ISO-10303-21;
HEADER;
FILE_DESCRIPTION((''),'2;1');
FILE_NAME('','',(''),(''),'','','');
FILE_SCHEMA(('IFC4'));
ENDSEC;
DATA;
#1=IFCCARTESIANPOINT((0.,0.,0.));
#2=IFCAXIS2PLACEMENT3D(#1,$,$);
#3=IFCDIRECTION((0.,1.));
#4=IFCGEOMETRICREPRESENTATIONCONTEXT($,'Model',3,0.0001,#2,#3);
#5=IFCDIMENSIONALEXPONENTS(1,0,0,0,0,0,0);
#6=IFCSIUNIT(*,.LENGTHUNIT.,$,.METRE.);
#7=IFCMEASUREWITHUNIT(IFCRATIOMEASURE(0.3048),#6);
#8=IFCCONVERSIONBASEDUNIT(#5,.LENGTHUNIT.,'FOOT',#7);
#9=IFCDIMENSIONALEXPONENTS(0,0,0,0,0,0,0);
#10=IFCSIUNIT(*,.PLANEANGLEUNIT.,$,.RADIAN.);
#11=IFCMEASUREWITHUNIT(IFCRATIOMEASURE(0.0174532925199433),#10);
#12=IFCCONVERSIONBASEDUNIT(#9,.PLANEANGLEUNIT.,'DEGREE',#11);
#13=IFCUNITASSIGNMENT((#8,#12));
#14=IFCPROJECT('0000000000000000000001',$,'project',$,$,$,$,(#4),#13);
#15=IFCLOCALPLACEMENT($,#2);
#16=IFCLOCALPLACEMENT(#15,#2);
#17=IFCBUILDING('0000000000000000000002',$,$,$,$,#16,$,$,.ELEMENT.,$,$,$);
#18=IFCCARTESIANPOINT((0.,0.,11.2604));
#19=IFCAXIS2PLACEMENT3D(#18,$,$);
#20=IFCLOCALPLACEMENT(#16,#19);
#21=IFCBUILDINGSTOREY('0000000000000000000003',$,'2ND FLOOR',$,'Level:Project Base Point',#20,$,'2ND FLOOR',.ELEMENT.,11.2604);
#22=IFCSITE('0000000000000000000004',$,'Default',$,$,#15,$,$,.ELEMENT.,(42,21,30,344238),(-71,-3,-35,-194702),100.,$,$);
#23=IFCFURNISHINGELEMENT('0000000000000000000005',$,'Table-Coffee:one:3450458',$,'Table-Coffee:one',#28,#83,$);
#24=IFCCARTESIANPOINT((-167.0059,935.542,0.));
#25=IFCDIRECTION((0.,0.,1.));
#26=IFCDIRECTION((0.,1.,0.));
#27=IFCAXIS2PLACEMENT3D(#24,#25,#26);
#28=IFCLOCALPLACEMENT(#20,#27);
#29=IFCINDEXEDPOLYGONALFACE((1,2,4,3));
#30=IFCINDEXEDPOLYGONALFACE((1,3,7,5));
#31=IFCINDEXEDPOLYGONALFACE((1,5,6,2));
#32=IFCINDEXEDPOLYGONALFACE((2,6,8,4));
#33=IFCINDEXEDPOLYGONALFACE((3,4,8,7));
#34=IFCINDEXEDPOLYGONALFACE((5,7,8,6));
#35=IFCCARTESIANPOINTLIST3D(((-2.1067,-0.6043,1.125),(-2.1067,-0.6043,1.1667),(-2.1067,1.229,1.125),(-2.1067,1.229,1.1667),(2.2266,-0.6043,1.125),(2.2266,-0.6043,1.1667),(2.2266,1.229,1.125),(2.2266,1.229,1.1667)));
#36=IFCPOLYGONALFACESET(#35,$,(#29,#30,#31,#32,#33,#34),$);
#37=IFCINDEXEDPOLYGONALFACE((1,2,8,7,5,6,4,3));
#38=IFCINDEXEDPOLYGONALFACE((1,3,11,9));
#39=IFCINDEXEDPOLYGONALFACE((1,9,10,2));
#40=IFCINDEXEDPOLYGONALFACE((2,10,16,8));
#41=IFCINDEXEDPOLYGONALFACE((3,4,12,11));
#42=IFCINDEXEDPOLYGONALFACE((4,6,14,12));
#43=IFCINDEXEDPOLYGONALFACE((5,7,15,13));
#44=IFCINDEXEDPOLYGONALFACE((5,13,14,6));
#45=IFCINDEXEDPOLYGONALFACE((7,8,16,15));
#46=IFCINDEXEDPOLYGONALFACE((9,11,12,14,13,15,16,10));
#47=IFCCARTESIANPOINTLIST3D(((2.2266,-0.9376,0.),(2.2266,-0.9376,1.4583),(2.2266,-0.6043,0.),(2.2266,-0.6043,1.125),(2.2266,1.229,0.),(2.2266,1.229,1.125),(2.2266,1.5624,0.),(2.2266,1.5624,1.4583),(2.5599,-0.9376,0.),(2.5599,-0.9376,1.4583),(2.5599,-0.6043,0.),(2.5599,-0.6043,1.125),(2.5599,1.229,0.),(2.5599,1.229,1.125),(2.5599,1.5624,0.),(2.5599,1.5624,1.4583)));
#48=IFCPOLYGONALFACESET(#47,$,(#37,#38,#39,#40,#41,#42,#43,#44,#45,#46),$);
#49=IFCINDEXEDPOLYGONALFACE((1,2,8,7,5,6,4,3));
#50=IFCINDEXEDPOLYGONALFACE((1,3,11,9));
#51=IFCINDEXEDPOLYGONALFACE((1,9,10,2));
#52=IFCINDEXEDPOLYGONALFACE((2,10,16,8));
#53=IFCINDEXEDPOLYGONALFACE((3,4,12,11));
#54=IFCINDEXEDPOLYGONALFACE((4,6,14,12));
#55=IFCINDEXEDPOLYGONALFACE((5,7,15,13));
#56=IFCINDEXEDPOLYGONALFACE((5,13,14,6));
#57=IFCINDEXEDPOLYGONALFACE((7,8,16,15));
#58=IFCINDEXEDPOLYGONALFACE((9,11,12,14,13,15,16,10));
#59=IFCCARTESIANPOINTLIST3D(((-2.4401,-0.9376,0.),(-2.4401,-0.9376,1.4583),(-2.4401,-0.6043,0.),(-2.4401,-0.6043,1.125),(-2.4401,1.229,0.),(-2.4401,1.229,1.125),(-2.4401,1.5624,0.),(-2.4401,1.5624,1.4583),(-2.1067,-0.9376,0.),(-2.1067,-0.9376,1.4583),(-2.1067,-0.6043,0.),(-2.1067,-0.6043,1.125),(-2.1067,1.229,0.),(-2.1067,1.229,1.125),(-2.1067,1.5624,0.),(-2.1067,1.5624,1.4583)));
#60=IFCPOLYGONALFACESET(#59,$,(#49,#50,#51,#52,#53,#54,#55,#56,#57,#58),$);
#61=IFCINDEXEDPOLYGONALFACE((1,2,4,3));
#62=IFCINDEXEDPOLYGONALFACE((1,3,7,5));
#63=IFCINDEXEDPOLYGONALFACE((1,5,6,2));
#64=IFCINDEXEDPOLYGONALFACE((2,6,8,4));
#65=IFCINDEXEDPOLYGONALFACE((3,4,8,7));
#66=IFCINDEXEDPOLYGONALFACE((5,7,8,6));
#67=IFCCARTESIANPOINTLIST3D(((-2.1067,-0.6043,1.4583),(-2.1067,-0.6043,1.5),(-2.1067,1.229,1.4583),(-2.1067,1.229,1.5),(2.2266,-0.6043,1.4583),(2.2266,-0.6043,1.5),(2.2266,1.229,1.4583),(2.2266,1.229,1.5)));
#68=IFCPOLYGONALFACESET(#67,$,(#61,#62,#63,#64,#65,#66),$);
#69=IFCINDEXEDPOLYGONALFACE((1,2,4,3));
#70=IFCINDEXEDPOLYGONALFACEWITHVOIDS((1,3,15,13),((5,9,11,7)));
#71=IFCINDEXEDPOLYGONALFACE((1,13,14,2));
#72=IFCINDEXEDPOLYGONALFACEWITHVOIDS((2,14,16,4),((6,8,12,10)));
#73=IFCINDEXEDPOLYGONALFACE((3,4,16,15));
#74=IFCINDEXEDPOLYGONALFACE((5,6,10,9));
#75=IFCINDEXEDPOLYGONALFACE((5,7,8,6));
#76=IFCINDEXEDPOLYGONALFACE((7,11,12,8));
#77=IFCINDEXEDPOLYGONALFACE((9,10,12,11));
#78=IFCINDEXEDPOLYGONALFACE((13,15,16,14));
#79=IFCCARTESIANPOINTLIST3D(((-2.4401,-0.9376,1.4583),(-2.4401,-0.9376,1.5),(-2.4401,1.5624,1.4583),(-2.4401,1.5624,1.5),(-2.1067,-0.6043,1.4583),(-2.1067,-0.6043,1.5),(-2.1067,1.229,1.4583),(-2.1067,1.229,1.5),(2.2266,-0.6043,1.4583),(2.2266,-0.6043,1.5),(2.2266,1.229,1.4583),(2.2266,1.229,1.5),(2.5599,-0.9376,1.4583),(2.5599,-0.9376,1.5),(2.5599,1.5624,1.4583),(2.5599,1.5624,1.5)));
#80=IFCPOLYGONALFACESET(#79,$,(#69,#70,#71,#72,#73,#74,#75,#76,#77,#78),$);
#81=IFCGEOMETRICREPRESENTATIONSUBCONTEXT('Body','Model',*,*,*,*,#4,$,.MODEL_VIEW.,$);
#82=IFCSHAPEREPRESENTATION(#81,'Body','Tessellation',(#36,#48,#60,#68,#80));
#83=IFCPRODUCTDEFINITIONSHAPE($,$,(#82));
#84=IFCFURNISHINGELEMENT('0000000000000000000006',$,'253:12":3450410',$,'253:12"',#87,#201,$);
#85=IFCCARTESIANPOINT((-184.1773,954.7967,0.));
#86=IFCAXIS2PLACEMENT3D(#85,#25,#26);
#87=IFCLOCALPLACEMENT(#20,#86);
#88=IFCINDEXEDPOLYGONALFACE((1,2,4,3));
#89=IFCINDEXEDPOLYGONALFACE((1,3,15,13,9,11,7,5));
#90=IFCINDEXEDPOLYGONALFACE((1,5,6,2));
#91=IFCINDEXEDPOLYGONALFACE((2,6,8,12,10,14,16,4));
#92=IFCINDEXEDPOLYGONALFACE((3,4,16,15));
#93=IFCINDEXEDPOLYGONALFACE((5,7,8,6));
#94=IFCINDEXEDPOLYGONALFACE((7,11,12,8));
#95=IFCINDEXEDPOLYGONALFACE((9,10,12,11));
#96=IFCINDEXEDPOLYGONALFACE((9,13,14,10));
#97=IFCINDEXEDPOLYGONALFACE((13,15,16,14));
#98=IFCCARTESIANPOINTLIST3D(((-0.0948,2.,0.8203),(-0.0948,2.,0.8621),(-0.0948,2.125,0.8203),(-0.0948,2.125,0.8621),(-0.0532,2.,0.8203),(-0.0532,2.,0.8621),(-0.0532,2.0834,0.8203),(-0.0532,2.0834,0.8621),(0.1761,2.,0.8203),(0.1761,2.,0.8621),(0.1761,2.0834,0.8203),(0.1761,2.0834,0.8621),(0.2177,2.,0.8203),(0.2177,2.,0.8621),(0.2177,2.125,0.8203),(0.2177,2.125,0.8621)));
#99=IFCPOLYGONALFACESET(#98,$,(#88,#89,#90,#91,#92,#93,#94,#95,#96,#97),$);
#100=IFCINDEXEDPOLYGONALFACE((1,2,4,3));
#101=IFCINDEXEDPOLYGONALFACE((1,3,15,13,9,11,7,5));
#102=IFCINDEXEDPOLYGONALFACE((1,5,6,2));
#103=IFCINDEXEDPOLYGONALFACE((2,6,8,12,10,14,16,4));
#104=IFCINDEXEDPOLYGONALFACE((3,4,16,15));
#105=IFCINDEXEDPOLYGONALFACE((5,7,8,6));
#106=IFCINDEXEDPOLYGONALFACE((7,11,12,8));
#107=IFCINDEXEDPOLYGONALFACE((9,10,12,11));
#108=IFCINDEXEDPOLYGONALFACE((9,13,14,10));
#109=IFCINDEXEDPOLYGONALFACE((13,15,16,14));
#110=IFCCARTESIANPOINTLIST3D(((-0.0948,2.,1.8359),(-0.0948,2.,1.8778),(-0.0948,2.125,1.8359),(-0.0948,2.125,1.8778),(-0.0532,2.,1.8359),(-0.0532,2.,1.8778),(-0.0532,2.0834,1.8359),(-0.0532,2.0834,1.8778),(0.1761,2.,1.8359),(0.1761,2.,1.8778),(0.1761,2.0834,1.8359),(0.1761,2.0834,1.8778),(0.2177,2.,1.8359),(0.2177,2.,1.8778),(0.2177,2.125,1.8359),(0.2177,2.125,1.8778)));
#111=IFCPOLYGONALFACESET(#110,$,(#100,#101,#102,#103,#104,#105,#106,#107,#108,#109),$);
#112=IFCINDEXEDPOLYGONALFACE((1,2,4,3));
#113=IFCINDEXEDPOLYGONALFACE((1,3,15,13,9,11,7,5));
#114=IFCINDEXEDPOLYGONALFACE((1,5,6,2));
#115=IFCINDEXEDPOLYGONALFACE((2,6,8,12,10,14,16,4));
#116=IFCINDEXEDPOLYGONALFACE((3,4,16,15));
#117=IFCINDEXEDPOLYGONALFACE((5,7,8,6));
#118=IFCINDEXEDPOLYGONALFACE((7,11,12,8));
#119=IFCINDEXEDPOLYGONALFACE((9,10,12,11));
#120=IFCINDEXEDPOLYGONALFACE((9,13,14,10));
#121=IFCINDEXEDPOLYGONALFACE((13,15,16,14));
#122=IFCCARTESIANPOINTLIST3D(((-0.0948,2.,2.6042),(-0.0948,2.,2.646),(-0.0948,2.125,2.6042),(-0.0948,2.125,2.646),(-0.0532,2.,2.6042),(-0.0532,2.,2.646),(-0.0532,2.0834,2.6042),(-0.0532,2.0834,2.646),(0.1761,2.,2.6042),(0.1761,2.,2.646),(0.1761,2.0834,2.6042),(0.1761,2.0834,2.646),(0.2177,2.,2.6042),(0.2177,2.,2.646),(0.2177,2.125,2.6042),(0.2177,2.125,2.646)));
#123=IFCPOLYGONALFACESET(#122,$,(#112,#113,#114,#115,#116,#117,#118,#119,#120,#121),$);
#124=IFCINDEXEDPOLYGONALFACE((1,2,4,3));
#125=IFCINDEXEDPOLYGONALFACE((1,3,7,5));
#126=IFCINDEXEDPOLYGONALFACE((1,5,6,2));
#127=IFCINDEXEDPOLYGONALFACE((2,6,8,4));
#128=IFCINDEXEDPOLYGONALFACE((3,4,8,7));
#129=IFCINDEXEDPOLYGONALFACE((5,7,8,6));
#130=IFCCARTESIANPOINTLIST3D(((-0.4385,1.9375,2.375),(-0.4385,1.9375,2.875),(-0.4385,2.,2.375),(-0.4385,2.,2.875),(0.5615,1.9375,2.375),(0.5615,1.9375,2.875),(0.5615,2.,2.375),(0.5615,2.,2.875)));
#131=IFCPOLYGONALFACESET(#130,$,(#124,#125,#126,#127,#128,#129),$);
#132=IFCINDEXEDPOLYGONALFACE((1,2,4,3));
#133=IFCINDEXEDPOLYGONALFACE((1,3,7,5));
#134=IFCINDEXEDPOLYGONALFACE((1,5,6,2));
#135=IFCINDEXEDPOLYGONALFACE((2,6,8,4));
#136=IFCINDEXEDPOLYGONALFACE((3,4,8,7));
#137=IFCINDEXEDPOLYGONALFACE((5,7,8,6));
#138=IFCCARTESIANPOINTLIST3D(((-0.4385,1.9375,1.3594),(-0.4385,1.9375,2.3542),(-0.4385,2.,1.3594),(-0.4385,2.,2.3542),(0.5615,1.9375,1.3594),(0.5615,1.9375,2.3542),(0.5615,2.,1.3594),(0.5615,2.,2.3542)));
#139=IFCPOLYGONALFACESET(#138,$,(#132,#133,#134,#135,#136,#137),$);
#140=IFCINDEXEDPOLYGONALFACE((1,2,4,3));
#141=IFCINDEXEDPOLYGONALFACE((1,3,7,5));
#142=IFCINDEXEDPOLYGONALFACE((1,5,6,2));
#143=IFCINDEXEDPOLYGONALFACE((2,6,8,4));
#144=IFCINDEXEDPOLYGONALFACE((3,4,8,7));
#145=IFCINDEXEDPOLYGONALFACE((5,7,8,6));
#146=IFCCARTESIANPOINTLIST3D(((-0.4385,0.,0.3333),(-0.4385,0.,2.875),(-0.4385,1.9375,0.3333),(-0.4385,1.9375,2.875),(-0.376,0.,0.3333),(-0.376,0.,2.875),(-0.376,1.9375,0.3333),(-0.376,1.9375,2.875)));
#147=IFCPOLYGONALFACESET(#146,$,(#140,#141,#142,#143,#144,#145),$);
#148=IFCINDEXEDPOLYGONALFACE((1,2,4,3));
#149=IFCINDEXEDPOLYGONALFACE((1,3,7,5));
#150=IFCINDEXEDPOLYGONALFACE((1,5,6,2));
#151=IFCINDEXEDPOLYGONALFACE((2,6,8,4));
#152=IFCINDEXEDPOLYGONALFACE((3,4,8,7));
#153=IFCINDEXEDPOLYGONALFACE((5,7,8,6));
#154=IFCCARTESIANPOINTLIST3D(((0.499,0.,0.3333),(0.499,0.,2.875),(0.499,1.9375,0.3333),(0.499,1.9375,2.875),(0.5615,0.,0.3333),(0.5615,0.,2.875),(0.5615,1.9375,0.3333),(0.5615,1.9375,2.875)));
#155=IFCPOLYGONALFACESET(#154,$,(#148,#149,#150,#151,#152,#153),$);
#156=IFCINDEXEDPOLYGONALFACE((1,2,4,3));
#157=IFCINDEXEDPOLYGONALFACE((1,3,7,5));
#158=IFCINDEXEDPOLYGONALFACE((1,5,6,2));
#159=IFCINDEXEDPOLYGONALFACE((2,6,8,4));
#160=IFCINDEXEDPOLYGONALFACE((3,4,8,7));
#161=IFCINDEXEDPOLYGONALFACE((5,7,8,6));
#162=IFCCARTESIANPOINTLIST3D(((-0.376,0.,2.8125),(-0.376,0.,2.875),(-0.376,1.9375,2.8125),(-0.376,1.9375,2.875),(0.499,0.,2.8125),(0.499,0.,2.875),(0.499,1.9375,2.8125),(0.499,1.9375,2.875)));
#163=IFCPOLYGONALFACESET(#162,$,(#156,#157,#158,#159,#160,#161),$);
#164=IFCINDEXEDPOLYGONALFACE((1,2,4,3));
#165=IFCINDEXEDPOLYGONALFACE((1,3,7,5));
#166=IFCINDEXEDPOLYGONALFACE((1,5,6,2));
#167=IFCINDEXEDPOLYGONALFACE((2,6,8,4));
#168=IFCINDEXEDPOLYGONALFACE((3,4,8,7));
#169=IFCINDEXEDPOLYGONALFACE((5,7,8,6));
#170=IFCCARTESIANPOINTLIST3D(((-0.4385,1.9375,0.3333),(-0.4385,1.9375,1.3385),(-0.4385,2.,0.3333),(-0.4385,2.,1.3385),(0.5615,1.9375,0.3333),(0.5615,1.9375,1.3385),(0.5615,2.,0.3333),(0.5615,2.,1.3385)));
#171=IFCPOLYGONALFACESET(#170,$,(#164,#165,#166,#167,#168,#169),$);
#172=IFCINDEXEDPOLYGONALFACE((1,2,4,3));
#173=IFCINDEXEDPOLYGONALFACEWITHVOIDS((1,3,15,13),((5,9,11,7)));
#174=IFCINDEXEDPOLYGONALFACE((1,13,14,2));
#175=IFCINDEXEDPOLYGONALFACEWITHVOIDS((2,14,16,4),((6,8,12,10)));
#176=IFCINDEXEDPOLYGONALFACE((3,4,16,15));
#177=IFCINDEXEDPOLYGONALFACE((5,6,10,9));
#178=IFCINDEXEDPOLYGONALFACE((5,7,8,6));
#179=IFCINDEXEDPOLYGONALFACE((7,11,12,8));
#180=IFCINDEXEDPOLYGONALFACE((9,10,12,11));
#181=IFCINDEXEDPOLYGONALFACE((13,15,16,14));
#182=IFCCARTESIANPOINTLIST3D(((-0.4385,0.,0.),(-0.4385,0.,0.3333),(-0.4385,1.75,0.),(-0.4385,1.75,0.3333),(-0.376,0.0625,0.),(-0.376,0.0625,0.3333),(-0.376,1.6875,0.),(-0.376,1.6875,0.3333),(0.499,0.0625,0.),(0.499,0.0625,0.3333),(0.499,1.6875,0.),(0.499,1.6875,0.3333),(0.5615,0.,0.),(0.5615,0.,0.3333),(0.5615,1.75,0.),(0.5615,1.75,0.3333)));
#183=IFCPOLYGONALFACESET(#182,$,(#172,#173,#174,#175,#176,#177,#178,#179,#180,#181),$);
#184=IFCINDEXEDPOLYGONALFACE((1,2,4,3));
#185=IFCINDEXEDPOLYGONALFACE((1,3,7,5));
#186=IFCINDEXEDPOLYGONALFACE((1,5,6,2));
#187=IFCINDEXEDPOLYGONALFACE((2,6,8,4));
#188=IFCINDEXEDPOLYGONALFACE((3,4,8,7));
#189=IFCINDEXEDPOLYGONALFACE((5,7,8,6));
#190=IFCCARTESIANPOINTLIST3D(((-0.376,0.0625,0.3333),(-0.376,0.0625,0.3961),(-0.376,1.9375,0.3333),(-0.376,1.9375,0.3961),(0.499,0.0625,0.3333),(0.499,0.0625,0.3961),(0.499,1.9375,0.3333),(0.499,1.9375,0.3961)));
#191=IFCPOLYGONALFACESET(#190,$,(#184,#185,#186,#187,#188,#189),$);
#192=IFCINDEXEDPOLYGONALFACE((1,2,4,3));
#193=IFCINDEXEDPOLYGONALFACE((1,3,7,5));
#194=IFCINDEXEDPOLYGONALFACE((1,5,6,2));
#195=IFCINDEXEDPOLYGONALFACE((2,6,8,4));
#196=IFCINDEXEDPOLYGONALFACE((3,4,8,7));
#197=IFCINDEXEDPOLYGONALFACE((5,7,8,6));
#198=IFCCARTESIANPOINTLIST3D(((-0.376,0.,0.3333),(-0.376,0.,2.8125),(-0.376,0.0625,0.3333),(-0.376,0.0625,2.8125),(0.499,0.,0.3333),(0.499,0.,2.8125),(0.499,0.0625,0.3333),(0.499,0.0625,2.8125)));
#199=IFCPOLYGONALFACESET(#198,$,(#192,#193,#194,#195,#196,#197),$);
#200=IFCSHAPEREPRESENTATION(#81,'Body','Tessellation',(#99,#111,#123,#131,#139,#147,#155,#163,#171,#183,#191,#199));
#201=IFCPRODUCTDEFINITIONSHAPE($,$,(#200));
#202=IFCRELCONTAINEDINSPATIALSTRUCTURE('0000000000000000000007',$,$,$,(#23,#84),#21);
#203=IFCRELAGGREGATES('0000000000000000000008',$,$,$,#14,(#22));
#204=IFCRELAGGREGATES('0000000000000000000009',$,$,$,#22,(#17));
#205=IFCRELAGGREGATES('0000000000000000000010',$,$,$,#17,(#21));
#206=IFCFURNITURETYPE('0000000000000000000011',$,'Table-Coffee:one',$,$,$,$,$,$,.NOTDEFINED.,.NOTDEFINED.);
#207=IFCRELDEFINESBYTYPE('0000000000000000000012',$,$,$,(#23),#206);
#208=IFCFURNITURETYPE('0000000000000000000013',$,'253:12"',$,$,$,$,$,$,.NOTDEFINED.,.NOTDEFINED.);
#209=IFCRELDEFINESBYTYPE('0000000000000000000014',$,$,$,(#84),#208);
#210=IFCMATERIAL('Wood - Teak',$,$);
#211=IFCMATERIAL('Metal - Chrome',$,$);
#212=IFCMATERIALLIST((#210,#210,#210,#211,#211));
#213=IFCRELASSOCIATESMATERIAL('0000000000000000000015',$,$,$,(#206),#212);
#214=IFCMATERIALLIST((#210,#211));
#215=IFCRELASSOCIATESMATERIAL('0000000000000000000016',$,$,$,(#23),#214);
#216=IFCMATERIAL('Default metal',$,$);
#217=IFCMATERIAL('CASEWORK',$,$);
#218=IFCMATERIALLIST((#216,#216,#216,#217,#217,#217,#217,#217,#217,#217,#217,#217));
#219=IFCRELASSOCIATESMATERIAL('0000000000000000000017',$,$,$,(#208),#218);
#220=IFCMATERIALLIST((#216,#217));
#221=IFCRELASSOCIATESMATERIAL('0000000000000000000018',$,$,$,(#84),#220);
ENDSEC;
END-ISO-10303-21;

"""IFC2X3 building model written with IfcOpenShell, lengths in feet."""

from ifc_helpers import new_model, entity, si_unit, converted_unit, direction, frame, frame_2d, origin, origin_2d_with_axis, place, context, subcontext, project, spatial, polyline, rectangle, outline, extrude, source, transform, mapped, material, material_list, type_object, type_shapes, element, save


model = new_model("IFC2X3")

# Units and contexts
model_context = context("Model", 3, precision=0.0001, world=origin(), true_north=direction((0.0, 1.0)))
body_context = subcontext(model_context, "Body", "Model", "MODEL_VIEW")
ifc_project = project(units=[converted_unit("LENGTHUNIT", "FOOT", entity("IfcRatioMeasure", 0.3048), si_unit("LENGTHUNIT", "METRE"), dimensions=[1, 0, 0, 0, 0, 0, 0]), converted_unit("PLANEANGLEUNIT", "DEGREE", entity("IfcRatioMeasure", 0.0174532925199433), si_unit("PLANEANGLEUNIT", "RADIAN"), dimensions=[0, 0, 0, 0, 0, 0, 0])], contexts=[model_context])

# Site, building, storey
site_placement = place(None, origin())
site = spatial("IfcSite", under=ifc_project, at=site_placement, Name="Default", CompositionType="ELEMENT", RefLatitude=(42, 21, 30, 344238), RefLongitude=(-71, -3, -35, -194702), RefElevation=100.0)
building_placement = place(site_placement, origin())
building = spatial("IfcBuilding", under=site, at=building_placement, CompositionType="ELEMENT")
storey_placement = place(building_placement, frame((0.0, 0.0, 11.2604)))
storey = spatial("IfcBuildingStorey", under=building, at=storey_placement, Name="2ND FLOOR", ObjectType="Level:Project Base Point", LongName="2ND FLOOR", CompositionType="ELEMENT", Elevation=11.2604)

# Furnishing elements
ifc_material_1 = material(Name="Wood - Teak")
ifc_material_2 = material(Name="Metal - Chrome")
ifc_material_list_1 = material_list([ifc_material_1, ifc_material_2])
ifc_material_list_2 = material_list([ifc_material_1, ifc_material_1, ifc_material_1, ifc_material_2, ifc_material_2])
furniture_type_1 = type_object("IfcFurnitureType", Name="Table-Coffee:one", material=ifc_material_list_2)
shared_shape_1 = source(origin(), body_context, "Body", "SweptSolid", [
    extrude(rectangle(XDim=4.3333, YDim=1.8333, at=origin_2d_with_axis()), frame((0.0599, 0.3124, 1.125), z_axis=(0.0, 0.0, 1.0), x_axis=(-1.0, 0.0, 0.0)), (0.0, 0.0, 1.0), 0.0417),
    extrude(outline(polyline([(-0.6458, -1.25), (0.8125, -1.25), (0.8125, 1.25), (-0.6458, 1.25), (-0.6458, 0.9167), (0.4792, 0.9167), (0.4792, -0.9167), (-0.6458, -0.9167), (-0.6458, -1.25)])), frame((2.2266, 0.3124, 0.6458), z_axis=(1.0, 0.0, 0.0), x_axis=(0.0, 0.0, 1.0)), (0.0, 0.0, 1.0), 0.3333),
    extrude(outline(polyline([(-1.25, -0.8125), (1.25, -0.8125), (1.25, 0.6458), (0.9167, 0.6458), (0.9167, -0.4792), (-0.9167, -0.4792), (-0.9167, 0.6458), (-1.25, 0.6458), (-1.25, -0.8125)])), frame((-2.4401, 0.3124, 0.6458), z_axis=(1.0, 0.0, 0.0), x_axis=(0.0, -1.0, 0.0)), (0.0, 0.0, 1.0), 0.3333),
    extrude(rectangle(XDim=4.3333, YDim=1.8333, at=origin_2d_with_axis()), frame((0.0599, 0.3124, 1.4583), z_axis=(0.0, 0.0, 1.0), x_axis=(-1.0, 0.0, 0.0)), (0.0, 0.0, 1.0), 0.0417),
    extrude(outline(polyline([(-2.5, -1.25), (2.5, -1.25), (2.5, 1.25), (-2.5, 1.25), (-2.5, -1.25)]), holes=[polyline([(-2.1667, -0.9167), (-2.1667, 0.9167), (2.1667, 0.9167), (2.1667, -0.9167), (-2.1667, -0.9167)])]), frame((0.0599, 0.3124, 1.4583), z_axis=(0.0, 0.0, 1.0), x_axis=(-1.0, 0.0, 0.0)), (0.0, 0.0, 1.0), 0.0417),
])
type_shapes(furniture_type_1, [shared_shape_1])
furnishing_1_placement = place(storey_placement, frame((-167.0059, 935.542, 0.0), z_axis=(0.0, 0.0, 1.0), x_axis=(0.0, 1.0, 0.0)))
element("IfcFurnishingElement", 1, at=furnishing_1_placement, inside=storey, type_object=furniture_type_1, material=ifc_material_list_1, Name="Table-Coffee:one:3450458", ObjectType="Table-Coffee:one", context=body_context, shape_type="MappedRepresentation", body=[
    mapped(shared_shape_1, transform((0.0, 0.0, 0.0), scale=1.0)),
])
ifc_material_3 = material(Name="Default metal")
ifc_material_4 = material(Name="CASEWORK")
ifc_material_list_3 = material_list([ifc_material_3, ifc_material_4])
ifc_material_list_4 = material_list([ifc_material_3, ifc_material_3, ifc_material_3, ifc_material_4, ifc_material_4, ifc_material_4, ifc_material_4, ifc_material_4, ifc_material_4, ifc_material_4, ifc_material_4, ifc_material_4])
furniture_type_2 = type_object("IfcFurnitureType", Name="253:12\"", material=ifc_material_list_4)
shared_shape_2 = source(origin(), body_context, "Body", "SweptSolid", [
    extrude(outline(polyline([(-0.1562, -0.0521), (-0.1146, -0.0521), (-0.1146, 0.0313), (0.1146, 0.0313), (0.1146, -0.0521), (0.1562, -0.0521), (0.1562, 0.0729), (-0.1562, 0.0729), (-0.1562, -0.0521)])), frame((0.0615, 2.0521, 0.8203)), (0.0, 0.0, 1.0), 0.0418),
    extrude(outline(polyline([(-0.1562, -0.0521), (-0.1146, -0.0521), (-0.1146, 0.0313), (0.1146, 0.0313), (0.1146, -0.0521), (0.1562, -0.0521), (0.1562, 0.0729), (-0.1562, 0.0729), (-0.1562, -0.0521)])), frame((0.0615, 2.0521, 1.8359)), (0.0, 0.0, 1.0), 0.0418),
    extrude(outline(polyline([(-0.1562, -0.0521), (-0.1146, -0.0521), (-0.1146, 0.0313), (0.1146, 0.0313), (0.1146, -0.0521), (0.1562, -0.0521), (0.1562, 0.0729), (-0.1562, 0.0729), (-0.1562, -0.0521)])), frame((0.0615, 2.0521, 2.6042)), (0.0, 0.0, 1.0), 0.0418),
    extrude(rectangle(XDim=1.0, YDim=0.0625, at=frame_2d((0.0, 0.0), x_axis=(1.0, 0.0))), frame((0.0615, 1.9688, 2.375), z_axis=(0.0, 0.0, 1.0), x_axis=(-1.0, 0.0, 0.0)), (0.0, 0.0, 1.0), 0.5),
    extrude(rectangle(XDim=1.0, YDim=0.0625, at=frame_2d((0.0, 0.0), x_axis=(1.0, 0.0))), frame((0.0615, 1.9688, 1.3594), z_axis=(0.0, 0.0, 1.0), x_axis=(-1.0, 0.0, 0.0)), (0.0, 0.0, 1.0), 0.9948),
    extrude(rectangle(XDim=1.9375, YDim=0.0625, at=frame_2d((0.0, 0.0), x_axis=(1.0, 0.0))), frame((-0.4073, 0.9687, 0.3333), z_axis=(0.0, 0.0, 1.0), x_axis=(0.0, -1.0, 0.0)), (0.0, 0.0, 1.0), 2.5417),
    extrude(rectangle(XDim=1.9375, YDim=0.0625, at=frame_2d((0.0, 0.0), x_axis=(1.0, 0.0))), frame((0.5302, 0.9687, 0.3333), z_axis=(0.0, 0.0, 1.0), x_axis=(0.0, -1.0, 0.0)), (0.0, 0.0, 1.0), 2.5417),
    extrude(rectangle(XDim=1.9375, YDim=0.875, at=origin_2d_with_axis()), frame((0.0615, 0.9688, 2.8125), z_axis=(0.0, 0.0, 1.0), x_axis=(0.0, 1.0, 0.0)), (0.0, 0.0, 1.0), 0.0625),
    extrude(rectangle(XDim=1.0, YDim=0.0625, at=frame_2d((0.0, 0.0), x_axis=(1.0, 0.0))), frame((0.0615, 1.9688, 0.3333), z_axis=(0.0, 0.0, 1.0), x_axis=(-1.0, 0.0, 0.0)), (0.0, 0.0, 1.0), 1.0052),
    extrude(outline(polyline([(-0.875, -0.5), (0.875, -0.5), (0.875, 0.5), (-0.875, 0.5), (-0.875, -0.5)]), holes=[polyline([(-0.8125, -0.4375), (-0.8125, 0.4375), (0.8125, 0.4375), (0.8125, -0.4375), (-0.8125, -0.4375)])]), frame((0.0615, 0.875, 0.0), z_axis=(0.0, 0.0, 1.0), x_axis=(0.0, -1.0, 0.0)), (0.0, 0.0, 1.0), 0.3333),
    extrude(rectangle(XDim=1.875, YDim=0.875, at=origin_2d_with_axis()), frame((0.0615, 1.0, 0.3333), z_axis=(0.0, 0.0, 1.0), x_axis=(0.0, 1.0, 0.0)), (0.0, 0.0, 1.0), 0.0627),
    extrude(rectangle(XDim=0.875, YDim=0.0625, at=origin_2d_with_axis()), frame((0.0615, 0.0312, 0.3333), z_axis=(0.0, 0.0, 1.0), x_axis=(-1.0, 0.0, 0.0)), (0.0, 0.0, 1.0), 2.4792),
])
type_shapes(furniture_type_2, [shared_shape_2])
furnishing_2_placement = place(storey_placement, frame((-184.1773, 954.7967, 0.0), z_axis=(0.0, 0.0, 1.0), x_axis=(0.0, 1.0, 0.0)))
element("IfcFurnishingElement", 2, at=furnishing_2_placement, inside=storey, type_object=furniture_type_2, material=ifc_material_list_3, Name="253:12\":3450410", ObjectType="253:12\"", context=body_context, shape_type="MappedRepresentation", body=[
    mapped(shared_shape_2, transform((0.0, 0.0, 0.0), scale=1.0)),
])

save(model, "model.ifc")
